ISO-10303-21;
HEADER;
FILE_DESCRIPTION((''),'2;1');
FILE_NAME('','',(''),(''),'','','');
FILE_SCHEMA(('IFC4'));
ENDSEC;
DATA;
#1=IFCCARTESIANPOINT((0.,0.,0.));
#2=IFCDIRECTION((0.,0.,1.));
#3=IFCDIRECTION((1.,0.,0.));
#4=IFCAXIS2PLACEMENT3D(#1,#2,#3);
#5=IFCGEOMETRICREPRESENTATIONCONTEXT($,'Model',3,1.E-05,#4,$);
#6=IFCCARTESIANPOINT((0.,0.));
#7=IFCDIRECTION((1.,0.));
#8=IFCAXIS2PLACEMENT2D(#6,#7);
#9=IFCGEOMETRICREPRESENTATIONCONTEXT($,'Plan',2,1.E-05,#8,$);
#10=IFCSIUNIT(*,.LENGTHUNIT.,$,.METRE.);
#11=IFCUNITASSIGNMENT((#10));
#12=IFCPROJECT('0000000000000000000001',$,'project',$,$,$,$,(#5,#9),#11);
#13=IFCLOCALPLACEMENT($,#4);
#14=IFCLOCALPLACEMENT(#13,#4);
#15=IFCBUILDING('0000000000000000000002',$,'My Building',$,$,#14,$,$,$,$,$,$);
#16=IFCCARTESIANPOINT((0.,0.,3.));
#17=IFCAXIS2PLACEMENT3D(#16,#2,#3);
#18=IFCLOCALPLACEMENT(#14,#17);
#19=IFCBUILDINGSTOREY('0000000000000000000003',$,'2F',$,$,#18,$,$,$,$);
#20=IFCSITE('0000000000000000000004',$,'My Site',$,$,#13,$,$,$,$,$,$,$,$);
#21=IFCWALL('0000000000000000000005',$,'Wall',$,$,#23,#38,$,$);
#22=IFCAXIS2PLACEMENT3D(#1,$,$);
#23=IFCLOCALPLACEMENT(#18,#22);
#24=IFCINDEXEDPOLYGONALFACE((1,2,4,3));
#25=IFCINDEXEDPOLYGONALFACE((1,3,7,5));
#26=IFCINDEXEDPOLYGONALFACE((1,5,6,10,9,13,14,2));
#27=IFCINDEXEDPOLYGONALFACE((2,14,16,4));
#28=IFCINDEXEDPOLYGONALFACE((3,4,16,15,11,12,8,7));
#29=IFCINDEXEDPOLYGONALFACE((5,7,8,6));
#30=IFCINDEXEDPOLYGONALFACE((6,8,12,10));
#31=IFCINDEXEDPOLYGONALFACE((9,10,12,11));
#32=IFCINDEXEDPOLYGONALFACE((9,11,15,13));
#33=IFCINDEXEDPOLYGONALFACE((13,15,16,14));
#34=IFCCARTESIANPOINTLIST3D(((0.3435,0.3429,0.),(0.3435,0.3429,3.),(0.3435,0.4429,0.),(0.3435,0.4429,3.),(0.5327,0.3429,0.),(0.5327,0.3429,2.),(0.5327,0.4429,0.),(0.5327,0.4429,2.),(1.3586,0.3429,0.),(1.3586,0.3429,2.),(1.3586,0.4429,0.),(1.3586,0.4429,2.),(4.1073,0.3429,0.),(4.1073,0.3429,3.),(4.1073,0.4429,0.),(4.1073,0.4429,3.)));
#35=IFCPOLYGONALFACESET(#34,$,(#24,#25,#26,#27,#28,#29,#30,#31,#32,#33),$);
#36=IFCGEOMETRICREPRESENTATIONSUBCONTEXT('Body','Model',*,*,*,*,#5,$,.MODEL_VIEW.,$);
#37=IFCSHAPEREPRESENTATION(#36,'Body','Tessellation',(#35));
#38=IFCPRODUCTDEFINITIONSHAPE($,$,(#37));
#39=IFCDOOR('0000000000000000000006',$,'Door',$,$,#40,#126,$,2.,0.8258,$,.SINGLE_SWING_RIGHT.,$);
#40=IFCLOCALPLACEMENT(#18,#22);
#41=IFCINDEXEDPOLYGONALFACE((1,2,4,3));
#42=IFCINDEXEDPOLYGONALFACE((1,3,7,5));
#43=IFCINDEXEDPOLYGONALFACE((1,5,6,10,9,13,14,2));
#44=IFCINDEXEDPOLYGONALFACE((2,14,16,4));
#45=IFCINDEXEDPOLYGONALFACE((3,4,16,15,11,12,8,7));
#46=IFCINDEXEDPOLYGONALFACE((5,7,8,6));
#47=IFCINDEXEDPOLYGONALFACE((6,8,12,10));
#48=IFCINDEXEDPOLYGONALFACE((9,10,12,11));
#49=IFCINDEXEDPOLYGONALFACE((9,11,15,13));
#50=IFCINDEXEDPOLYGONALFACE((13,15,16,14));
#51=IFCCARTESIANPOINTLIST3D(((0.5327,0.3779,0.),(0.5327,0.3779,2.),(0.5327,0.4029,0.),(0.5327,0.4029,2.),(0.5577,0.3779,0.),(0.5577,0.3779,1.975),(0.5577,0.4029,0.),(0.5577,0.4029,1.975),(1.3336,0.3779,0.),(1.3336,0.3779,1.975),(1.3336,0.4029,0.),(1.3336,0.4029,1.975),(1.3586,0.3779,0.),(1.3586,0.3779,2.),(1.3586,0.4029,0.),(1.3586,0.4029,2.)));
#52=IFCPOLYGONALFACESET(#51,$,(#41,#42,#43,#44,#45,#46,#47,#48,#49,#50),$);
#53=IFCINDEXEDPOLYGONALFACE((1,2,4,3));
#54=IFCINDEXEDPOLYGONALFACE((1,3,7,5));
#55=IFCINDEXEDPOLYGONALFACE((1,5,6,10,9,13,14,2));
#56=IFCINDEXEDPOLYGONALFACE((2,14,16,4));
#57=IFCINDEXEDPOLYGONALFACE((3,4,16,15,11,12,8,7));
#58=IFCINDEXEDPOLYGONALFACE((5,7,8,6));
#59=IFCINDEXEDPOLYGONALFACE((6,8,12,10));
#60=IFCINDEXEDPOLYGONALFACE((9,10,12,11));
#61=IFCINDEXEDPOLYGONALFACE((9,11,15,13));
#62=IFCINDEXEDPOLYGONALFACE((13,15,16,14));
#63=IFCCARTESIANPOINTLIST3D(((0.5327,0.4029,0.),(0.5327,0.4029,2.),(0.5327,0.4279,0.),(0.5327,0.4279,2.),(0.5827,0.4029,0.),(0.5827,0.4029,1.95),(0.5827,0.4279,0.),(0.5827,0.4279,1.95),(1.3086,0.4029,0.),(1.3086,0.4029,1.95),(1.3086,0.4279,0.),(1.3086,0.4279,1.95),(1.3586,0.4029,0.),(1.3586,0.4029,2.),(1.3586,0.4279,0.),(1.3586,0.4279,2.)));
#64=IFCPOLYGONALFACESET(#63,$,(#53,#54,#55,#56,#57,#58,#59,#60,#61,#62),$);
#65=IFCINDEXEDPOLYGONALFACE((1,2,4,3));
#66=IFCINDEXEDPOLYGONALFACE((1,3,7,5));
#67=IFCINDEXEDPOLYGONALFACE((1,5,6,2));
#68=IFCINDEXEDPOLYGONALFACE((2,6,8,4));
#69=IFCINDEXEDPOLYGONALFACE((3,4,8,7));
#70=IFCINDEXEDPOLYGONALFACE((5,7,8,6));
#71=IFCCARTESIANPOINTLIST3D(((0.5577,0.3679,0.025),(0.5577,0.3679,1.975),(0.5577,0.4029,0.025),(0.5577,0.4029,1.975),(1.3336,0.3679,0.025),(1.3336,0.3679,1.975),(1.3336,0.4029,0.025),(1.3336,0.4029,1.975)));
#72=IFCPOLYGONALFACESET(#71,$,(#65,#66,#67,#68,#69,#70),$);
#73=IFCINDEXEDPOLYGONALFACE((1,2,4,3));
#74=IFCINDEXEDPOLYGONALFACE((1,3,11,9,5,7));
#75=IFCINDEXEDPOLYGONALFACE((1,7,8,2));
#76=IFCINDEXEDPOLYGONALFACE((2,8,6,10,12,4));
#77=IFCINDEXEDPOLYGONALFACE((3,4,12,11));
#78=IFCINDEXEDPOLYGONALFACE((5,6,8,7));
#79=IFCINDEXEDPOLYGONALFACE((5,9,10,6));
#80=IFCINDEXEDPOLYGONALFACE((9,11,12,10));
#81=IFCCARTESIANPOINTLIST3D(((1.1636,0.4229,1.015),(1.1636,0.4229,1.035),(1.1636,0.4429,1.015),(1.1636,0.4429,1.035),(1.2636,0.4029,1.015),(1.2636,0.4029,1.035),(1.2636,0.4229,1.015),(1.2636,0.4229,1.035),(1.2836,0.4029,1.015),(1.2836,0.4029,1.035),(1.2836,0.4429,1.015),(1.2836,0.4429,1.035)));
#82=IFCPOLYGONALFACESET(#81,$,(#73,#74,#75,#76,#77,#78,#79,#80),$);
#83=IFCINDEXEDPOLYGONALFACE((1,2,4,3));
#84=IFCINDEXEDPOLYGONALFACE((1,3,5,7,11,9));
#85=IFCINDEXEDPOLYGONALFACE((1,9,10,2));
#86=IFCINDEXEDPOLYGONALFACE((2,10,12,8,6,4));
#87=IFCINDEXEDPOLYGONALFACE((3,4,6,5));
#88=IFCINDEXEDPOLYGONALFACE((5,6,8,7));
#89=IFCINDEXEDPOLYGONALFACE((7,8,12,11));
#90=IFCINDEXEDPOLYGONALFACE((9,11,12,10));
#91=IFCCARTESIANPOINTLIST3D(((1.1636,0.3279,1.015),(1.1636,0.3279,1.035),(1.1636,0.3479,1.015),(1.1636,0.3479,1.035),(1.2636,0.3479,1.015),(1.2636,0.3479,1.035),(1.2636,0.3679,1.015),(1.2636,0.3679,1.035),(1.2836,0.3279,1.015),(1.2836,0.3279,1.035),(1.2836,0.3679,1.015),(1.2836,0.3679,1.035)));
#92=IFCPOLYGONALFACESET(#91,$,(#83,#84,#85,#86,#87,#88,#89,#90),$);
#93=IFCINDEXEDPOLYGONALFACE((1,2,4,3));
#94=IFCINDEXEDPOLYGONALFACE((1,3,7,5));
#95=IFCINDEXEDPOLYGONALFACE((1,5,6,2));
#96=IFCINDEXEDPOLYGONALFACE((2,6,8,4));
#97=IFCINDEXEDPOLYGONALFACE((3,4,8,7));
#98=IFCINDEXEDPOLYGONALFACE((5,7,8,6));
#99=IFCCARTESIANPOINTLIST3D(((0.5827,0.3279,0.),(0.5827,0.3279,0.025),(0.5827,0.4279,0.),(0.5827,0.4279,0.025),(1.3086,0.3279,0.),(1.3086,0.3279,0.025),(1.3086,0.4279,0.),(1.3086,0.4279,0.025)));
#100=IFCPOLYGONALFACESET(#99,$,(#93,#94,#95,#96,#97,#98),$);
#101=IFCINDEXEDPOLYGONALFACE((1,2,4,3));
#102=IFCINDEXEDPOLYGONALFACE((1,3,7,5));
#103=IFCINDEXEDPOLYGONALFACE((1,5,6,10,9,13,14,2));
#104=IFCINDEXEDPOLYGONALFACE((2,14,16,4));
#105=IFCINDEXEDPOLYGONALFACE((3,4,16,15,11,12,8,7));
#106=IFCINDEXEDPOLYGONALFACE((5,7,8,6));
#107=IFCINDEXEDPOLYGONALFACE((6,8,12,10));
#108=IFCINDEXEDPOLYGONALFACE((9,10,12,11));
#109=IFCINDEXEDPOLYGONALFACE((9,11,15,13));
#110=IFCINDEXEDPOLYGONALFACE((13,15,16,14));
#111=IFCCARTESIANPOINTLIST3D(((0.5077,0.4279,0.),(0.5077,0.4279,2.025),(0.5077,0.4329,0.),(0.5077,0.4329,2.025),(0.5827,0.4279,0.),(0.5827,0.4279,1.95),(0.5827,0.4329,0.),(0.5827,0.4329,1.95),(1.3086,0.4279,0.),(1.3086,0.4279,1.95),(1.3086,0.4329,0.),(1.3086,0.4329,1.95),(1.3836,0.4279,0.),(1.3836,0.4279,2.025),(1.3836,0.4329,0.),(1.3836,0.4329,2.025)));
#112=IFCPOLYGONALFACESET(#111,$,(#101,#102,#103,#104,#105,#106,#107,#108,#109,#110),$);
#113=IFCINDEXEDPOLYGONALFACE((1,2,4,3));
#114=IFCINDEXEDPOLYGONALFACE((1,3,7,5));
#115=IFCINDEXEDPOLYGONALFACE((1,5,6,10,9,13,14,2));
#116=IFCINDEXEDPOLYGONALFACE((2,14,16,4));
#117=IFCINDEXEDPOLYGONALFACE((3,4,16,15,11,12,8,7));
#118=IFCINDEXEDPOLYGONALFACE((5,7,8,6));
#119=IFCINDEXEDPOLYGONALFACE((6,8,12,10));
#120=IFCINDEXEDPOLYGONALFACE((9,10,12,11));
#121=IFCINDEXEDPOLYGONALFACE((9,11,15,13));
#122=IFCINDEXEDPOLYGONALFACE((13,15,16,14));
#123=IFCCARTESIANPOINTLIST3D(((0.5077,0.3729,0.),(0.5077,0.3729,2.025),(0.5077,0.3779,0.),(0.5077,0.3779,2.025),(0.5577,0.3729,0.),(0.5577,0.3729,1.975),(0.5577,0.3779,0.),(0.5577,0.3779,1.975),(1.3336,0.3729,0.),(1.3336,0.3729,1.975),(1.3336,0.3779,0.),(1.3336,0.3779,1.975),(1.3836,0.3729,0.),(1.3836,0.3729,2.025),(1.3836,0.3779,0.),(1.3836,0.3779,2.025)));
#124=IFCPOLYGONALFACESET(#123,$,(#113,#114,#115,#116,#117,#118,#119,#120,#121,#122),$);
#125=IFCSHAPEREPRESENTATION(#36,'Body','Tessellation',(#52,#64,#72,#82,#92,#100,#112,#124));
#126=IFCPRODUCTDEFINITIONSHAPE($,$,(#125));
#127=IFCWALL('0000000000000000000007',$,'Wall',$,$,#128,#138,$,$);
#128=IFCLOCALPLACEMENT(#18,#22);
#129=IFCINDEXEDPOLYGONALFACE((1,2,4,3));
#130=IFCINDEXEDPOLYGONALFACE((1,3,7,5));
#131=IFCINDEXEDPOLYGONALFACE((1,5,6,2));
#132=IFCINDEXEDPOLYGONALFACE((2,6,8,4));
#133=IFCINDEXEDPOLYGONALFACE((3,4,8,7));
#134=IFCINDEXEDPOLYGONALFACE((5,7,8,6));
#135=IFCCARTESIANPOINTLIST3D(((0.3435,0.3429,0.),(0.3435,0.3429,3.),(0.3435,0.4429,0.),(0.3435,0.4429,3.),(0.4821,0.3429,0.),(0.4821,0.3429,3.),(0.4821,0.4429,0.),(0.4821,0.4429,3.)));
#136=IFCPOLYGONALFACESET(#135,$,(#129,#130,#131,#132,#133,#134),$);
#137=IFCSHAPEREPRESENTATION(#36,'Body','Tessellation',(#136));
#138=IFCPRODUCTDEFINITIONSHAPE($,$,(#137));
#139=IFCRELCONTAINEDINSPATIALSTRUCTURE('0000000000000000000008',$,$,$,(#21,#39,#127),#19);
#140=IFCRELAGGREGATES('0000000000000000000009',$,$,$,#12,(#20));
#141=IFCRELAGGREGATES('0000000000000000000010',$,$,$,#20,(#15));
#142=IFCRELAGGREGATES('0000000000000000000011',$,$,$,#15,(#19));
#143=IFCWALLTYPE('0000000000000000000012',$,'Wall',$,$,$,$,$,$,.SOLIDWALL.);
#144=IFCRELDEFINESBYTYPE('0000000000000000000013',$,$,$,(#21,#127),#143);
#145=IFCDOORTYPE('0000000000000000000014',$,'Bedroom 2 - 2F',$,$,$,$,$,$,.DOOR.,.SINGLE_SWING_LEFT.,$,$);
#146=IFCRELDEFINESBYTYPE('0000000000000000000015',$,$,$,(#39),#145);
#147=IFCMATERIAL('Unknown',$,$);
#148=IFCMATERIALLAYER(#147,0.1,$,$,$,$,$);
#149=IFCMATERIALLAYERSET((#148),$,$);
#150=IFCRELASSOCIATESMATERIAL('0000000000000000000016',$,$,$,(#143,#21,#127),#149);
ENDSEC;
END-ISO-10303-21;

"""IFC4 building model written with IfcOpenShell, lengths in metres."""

from ifc_helpers import new_model, entity, si_unit, frame, origin_with_axes, origin_2d_with_axis, place, context, subcontext, project, spatial, line, indexed_curve, outline, extrude, shape, source, transform, mapped, material, layer, layer_set, layer_usage, type_object, type_shapes, element, fill, save


model = new_model("IFC4")

# Units and contexts
model_context = context("Model", 3, precision=1e-05, world=origin_with_axes())
plan_context = context("Plan", 2, precision=1e-05, world=origin_2d_with_axis())
body_context_1 = subcontext(model_context, "Body", "Model", "MODEL_VIEW")
body_context_2 = subcontext(plan_context, "Body", "Plan", "PLAN_VIEW")
ifc_project = project(units=[si_unit("LENGTHUNIT", "METRE")], contexts=[model_context, plan_context])

# Site, building, storey
site_placement = place(None, origin_with_axes())
site = spatial("IfcSite", under=ifc_project, at=site_placement, Name="My Site")
building_placement = place(site_placement, origin_with_axes())
building = spatial("IfcBuilding", under=site, at=building_placement, Name="My Building")
storey_placement = place(building_placement, frame((0.0, 0.0, 3.0), z_axis=(0.0, 0.0, 1.0), x_axis=(1.0, 0.0, 0.0)))
storey = spatial("IfcBuildingStorey", under=building, at=storey_placement, Name="2F")

# Shared definitions
ifc_material = material(Name="Unknown")

# Shared definitions
ifc_layer_1 = layer(ifc_material, 0.1)
ifc_layer_set_1 = layer_set([ifc_layer_1])
wall_type = type_object("IfcWallType", Name="Wall", PredefinedType="SOLIDWALL", material=ifc_layer_set_1)

# Wall, opening, door
ifc_layer_usage_1 = layer_usage(ifc_layer_set_1, "AXIS2", "POSITIVE", 0.0)
wall_1_placement = place(storey_placement, frame((4.2073, 0.4429, 0.0), z_axis=(0.0, 0.0, 1.0), x_axis=(-1.0, 0.0, 0.0)))
wall_1 = element("IfcWall", 1, at=wall_1_placement, inside=storey, type_object=wall_type, material=ifc_layer_usage_1, Name="Wall", context=body_context_1, shape_type="SweptSolid", body=[
    extrude(outline(indexed_curve([(0.1, 0.0), (0.1, 0.1), (3.8638, 0.1), (3.8638, 0.0)], segments=[line(1, 2, 3, 4, 1)])), origin_with_axes(), (0.0, 0.0, 1.0), 3.0),
])
shared_shape_1 = source(origin_with_axes(), body_context_1, "Body", "SweptSolid", [
    extrude(outline(indexed_curve([(0.0, 0.0), (0.8258, 0.0), (0.8258, 2.0), (0.0, 2.0)], segments=[line(1, 2, 3, 4, 1)])), frame((0.0, -0.6, 0.0), z_axis=(0.0, -1.0, 0.0), x_axis=(1.0, 0.0, 0.0)), (0.0, 0.0, -1.0), 1.2),
])
opening_1_placement = place(wall_1_placement, frame((2.8487, 0.015, 0.0), z_axis=(0.0, 0.0, 1.0), x_axis=(1.0, -0.000001, 0.0)))
opening_1 = element("IfcOpeningElement", 2, at=opening_1_placement, cuts=wall_1, PredefinedType="OPENING", context=body_context_1, shape_type="MappedRepresentation", body=[
    mapped(shared_shape_1, transform((0.0, 0.0, 0.0), x_axis=(1.0, 0.0, 0.0), y_axis=(0.0, 1.0, 0.0), z_axis=(0.0, 0.0, 1.0), scale=1.0)),
])
door_type_1 = type_object("IfcDoorType", Name="Bedroom 2 - 2F", OperationType="SINGLE_SWING_LEFT", PredefinedType="DOOR")
shared_shape_2 = source(origin_with_axes(), body_context_1, "Body", "SweptSolid", [
    extrude(outline(indexed_curve([(0.0, 0.0), (0.0, 2.0), (0.8258, 2.0), (0.8258, 0.0), (0.8008, 0.0), (0.8008, 1.975), (0.025, 1.975), (0.025, 0.0)], segments=[line(1, 2, 3, 4, 5, 6, 7, 8, 1)])), frame((0.0, 0.025, 0.0), z_axis=(0.0, -1.0, 0.0), x_axis=(1.0, 0.0, 0.0)), (0.0, 0.0, -1.0), 0.025),
    extrude(outline(indexed_curve([(0.0, 0.0), (0.0, 2.0), (0.8258, 2.0), (0.8258, 0.0), (0.7758, 0.0), (0.7758, 1.95), (0.05, 1.95), (0.05, 0.0)], segments=[line(1, 2, 3, 4, 5, 6, 7, 8, 1)])), frame((0.0, 0.0, 0.0), z_axis=(0.0, -1.0, 0.0), x_axis=(1.0, 0.0, 0.0)), (0.0, 0.0, -1.0), 0.025),
    extrude(outline(indexed_curve([(0.0, 0.0), (0.7758, 0.0), (0.7758, 0.035), (0.0, 0.035)], segments=[line(1, 2, 3, 4, 1)])), frame((0.025, 0.025, 0.025), z_axis=(0.0, 0.0, 1.0), x_axis=(1.0, 0.0, 0.0)), (0.0, 0.0, 1.0), 1.95),
    extrude(outline(indexed_curve([(0.0, 0.0), (0.0, -0.04), (0.12, -0.04), (0.12, -0.02), (0.02, -0.02), (0.02, 0.0)], segments=[line(1, 2, 3, 4, 5, 6, 1)])), frame((0.075, 0.025, 1.015), z_axis=(0.0, 0.0, 1.0), x_axis=(1.0, 0.0, 0.0)), (0.0, 0.0, 1.0), 0.02),
    extrude(outline(indexed_curve([(0.0, 0.0), (0.0, 0.04), (0.12, 0.04), (0.12, 0.02), (0.02, 0.02), (0.02, 0.0)], segments=[line(1, 2, 3, 4, 5, 6, 1)])), frame((0.075, 0.06, 1.015), z_axis=(0.0, 0.0, 1.0), x_axis=(1.0, 0.0, 0.0)), (0.0, 0.0, 1.0), 0.02),
    extrude(outline(indexed_curve([(0.0, 0.0), (0.7258, 0.0), (0.7258, 0.1), (0.0, 0.1)], segments=[line(1, 2, 3, 4, 1)])), frame((0.05, 0.0, 0.0), z_axis=(0.0, 0.0, 1.0), x_axis=(1.0, 0.0, 0.0)), (0.0, 0.0, 1.0), 0.025),
    extrude(outline(indexed_curve([(0.0, 0.0), (0.0, 2.025), (0.8758, 2.025), (0.8758, 0.0), (0.8008, 0.0), (0.8008, 1.95), (0.075, 1.95), (0.075, 0.0)], segments=[line(1, 2, 3, 4, 5, 6, 7, 8, 1)])), frame((-0.025, -0.005, 0.0), z_axis=(0.0, -1.0, 0.0), x_axis=(1.0, 0.0, 0.0)), (0.0, 0.0, -1.0), 0.005),
    extrude(outline(indexed_curve([(0.0, 0.0), (0.0, 2.025), (0.8758, 2.025), (0.8758, 0.0), (0.8258, 0.0), (0.8258, 1.975), (0.05, 1.975), (0.05, 0.0)], segments=[line(1, 2, 3, 4, 5, 6, 7, 8, 1)])), frame((-0.025, 0.05, 0.0), z_axis=(0.0, -1.0, 0.0), x_axis=(1.0, 0.0, 0.0)), (0.0, 0.0, -1.0), 0.005),
])
shared_shape_3 = source(origin_with_axes(), body_context_2, "Body", "Curve2D", [
    entity("IfcIndexedPolyCurve", entity("IfcCartesianPointList2D", [[0.0, 0.0], [0.0, 0.05], [0.025, 0.05], [0.025, 0.025], [0.05, 0.025], [0.05, 0.0]]), [entity("IfcLineIndex", [1, 2, 3, 4, 5, 6, 1])]),
    entity("IfcIndexedPolyCurve", entity("IfcCartesianPointList2D", [[0.8258, 0.0], [0.8258, 0.05], [0.8008, 0.05], [0.8008, 0.025], [0.7758, 0.025], [0.7758, 0.0]]), [entity("IfcLineIndex", [1, 2, 3, 4, 5, 6, 1])]),
    entity("IfcTrimmedCurve", entity("IfcEllipse", entity("IfcAxis2Placement2D", entity("IfcCartesianPoint", [0.7658, 0.05]), entity("IfcDirection", [1.0, 0.0])), 0.7408, 0.7758), [entity("IfcCartesianPoint", [0.7658, 0.8258])], [entity("IfcCartesianPoint", [0.025, 0.05])], True, "CARTESIAN"),
    entity("IfcIndexedPolyCurve", entity("IfcCartesianPointList2D", [[0.8008, 0.05], [0.7658, 0.05], [0.7658, 0.8258], [0.8008, 0.8258]]), [entity("IfcLineIndex", [1, 2, 3, 4, 1])]),
])
type_shapes(door_type_1, [shared_shape_2, shared_shape_3])
door_1_placement = place(opening_1_placement, frame((0.0, 0.0, 0.0), z_axis=(0.0, 0.0, 1.0), x_axis=(1.0, 0.0, 0.0)))
door_1 = element("IfcDoor", 3, at=door_1_placement, inside=storey, type_object=door_type_1, Name="Door", OperationType="SINGLE_SWING_RIGHT", OverallHeight=2.0, OverallWidth=0.8258, shapes=[
    shape(body_context_1, "Body", "MappedRepresentation", [mapped(shared_shape_2, transform((0.0, 0.0, 0.0), x_axis=(1.0, 0.0, 0.0), y_axis=(0.0, 1.0, 0.0), z_axis=(0.0, 0.0, 1.0), scale=1.0))]),
    shape(body_context_2, "Body", "MappedRepresentation", [mapped(shared_shape_3, transform((0.0, 0.0, 0.0), x_axis=(1.0, 0.0, 0.0), y_axis=(0.0, 1.0, 0.0), z_axis=(0.0, 0.0, 1.0), scale=1.0))]),
])
fill(opening_1, door_1)

# Wall
ifc_layer_usage_2 = layer_usage(ifc_layer_set_1, "AXIS2", "POSITIVE", 0.0)
wall_2_placement = place(storey_placement, frame((0.4821, 0.4429, 0.0), z_axis=(0.0, 0.0, 1.0), x_axis=(-1.0, 0.0, 0.0)))
element("IfcWall", 4, at=wall_2_placement, inside=storey, type_object=wall_type, material=ifc_layer_usage_2, Name="Wall", context=body_context_1, shape_type="SweptSolid", body=[
    extrude(outline(indexed_curve([(0.0, 0.0), (0.0, 0.1), (0.1387, 0.1), (0.1387, 0.0)], segments=[line(1, 2, 3, 4, 1)])), origin_with_axes(), (0.0, 0.0, 1.0), 3.0),
])

save(model, "model.ifc")
